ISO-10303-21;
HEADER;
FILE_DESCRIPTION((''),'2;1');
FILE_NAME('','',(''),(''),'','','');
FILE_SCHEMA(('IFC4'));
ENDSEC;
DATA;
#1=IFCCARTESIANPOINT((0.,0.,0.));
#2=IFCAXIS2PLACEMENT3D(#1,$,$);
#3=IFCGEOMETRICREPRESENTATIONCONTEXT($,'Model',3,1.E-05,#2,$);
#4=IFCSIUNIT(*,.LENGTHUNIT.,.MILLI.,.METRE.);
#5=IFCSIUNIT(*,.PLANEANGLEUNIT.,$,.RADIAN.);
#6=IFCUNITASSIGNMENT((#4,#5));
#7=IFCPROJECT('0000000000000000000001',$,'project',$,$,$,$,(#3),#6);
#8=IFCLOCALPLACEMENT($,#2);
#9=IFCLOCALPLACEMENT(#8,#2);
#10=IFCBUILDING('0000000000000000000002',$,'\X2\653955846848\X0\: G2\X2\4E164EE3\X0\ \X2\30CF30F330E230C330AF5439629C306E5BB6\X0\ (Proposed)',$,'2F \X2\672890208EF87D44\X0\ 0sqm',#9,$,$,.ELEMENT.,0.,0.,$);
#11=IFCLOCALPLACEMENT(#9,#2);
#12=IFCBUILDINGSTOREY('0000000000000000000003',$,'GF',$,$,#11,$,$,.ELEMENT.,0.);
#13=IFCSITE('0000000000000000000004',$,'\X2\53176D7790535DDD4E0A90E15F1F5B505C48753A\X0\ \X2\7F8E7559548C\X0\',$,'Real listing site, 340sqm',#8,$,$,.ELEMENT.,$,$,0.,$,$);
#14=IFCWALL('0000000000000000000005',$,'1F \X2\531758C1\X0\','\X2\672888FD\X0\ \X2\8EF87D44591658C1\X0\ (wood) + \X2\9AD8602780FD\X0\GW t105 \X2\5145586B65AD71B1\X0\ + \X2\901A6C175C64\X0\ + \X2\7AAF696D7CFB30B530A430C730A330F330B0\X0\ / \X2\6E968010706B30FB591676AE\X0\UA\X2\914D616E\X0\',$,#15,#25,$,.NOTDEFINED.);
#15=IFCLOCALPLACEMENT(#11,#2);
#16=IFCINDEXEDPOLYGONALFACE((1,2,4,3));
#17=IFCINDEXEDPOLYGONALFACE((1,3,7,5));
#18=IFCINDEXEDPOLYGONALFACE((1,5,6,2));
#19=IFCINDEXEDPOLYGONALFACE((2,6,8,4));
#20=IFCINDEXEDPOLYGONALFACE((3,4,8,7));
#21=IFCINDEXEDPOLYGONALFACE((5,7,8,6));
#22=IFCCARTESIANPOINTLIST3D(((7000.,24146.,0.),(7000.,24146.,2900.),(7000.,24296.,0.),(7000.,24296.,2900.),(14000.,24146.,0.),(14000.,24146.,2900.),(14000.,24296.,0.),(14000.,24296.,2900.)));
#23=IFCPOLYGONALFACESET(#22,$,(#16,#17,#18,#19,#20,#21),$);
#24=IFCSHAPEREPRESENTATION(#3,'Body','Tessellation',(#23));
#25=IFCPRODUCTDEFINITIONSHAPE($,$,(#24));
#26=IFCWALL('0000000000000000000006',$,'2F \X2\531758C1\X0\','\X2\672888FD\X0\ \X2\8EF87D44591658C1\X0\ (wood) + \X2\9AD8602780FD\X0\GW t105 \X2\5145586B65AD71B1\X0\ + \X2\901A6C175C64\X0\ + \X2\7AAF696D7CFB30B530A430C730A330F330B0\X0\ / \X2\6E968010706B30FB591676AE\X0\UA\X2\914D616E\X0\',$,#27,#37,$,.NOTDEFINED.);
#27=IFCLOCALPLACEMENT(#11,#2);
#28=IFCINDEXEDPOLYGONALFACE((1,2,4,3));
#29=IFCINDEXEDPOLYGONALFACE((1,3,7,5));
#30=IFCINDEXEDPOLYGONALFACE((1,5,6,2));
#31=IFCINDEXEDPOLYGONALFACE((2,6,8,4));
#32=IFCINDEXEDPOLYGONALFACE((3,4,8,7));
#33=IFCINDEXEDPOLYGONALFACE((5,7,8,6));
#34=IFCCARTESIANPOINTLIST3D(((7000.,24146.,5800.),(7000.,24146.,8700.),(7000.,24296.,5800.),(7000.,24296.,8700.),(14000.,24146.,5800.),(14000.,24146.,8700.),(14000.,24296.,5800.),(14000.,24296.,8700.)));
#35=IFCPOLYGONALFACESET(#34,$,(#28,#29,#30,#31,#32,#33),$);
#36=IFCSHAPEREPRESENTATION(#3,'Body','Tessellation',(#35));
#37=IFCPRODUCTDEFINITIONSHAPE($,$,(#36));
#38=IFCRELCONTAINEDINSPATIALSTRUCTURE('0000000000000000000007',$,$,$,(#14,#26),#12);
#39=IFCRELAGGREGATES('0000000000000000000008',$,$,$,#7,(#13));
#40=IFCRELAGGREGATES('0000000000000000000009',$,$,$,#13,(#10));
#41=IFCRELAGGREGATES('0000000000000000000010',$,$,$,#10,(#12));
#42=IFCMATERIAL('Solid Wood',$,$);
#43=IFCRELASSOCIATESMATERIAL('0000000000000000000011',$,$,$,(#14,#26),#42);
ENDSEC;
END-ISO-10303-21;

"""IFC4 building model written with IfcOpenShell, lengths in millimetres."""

from ifc_helpers import new_model, si_unit, frame, frame_2d, origin, place, context, project, spatial, rectangle, extrude, material, element, save


model = new_model("IFC4")

# Units and contexts
model_context = context("Model", 3, precision=1e-05, world=origin())
ifc_project = project(units=[si_unit("LENGTHUNIT", "METRE", prefix="MILLI"), si_unit("PLANEANGLEUNIT", "RADIAN")], contexts=[model_context])

# Site, building, storey
site_placement = place(None, origin())
site = spatial("IfcSite", under=ifc_project, at=site_placement, Name="北海道川上郡弟子屈町 美留和", ObjectType="Real listing site, 340sqm", CompositionType="ELEMENT", RefElevation=0.0)
building_placement = place(site_placement, origin())
building = spatial("IfcBuilding", under=site, at=building_placement, Name="改善案: G2世代 ハンモック吹抜の家 (Proposed)", ObjectType="2F 木造軸組 0sqm", CompositionType="ELEMENT", ElevationOfRefHeight=0.0, ElevationOfTerrain=0.0)
storey_placement = place(building_placement, origin())
storey = spatial("IfcBuildingStorey", under=building, at=storey_placement, Name="GF", CompositionType="ELEMENT", Elevation=0.0)

# Shared definitions
ifc_material_1 = material(Name="Solid Wood")

# Wall
wall_1_placement = place(storey_placement, frame((3500.0, 12073.0, 0.0)))
element("IfcWall", 1, at=wall_1_placement, inside=storey, material=ifc_material_1, Name="1F 北壁", Description="木製 軸組外壁 (wood) + 高性能GW t105 充填断熱 + 通気層 + 窯業系サイディング / 準耐火・外皮UA配慮", PredefinedType="NOTDEFINED", context=model_context, shape_type="SweptSolid", body=[
    extrude(rectangle(XDim=7000.0, YDim=150.0, at=frame_2d((3500.0, 75.0))), frame((3500.0, 12073.0, 0.0)), (0.0, 0.0, 1.0), 2900.0),
])

# Wall
wall_2_placement = place(storey_placement, frame((3500.0, 12073.0, 2900.0)))
element("IfcWall", 2, at=wall_2_placement, inside=storey, material=ifc_material_1, Name="2F 北壁", Description="木製 軸組外壁 (wood) + 高性能GW t105 充填断熱 + 通気層 + 窯業系サイディング / 準耐火・外皮UA配慮", PredefinedType="NOTDEFINED", context=model_context, shape_type="SweptSolid", body=[
    extrude(rectangle(XDim=7000.0, YDim=150.0, at=frame_2d((3500.0, 75.0))), frame((3500.0, 12073.0, 2900.0)), (0.0, 0.0, 1.0), 2900.0),
])

save(model, "model.ifc")
